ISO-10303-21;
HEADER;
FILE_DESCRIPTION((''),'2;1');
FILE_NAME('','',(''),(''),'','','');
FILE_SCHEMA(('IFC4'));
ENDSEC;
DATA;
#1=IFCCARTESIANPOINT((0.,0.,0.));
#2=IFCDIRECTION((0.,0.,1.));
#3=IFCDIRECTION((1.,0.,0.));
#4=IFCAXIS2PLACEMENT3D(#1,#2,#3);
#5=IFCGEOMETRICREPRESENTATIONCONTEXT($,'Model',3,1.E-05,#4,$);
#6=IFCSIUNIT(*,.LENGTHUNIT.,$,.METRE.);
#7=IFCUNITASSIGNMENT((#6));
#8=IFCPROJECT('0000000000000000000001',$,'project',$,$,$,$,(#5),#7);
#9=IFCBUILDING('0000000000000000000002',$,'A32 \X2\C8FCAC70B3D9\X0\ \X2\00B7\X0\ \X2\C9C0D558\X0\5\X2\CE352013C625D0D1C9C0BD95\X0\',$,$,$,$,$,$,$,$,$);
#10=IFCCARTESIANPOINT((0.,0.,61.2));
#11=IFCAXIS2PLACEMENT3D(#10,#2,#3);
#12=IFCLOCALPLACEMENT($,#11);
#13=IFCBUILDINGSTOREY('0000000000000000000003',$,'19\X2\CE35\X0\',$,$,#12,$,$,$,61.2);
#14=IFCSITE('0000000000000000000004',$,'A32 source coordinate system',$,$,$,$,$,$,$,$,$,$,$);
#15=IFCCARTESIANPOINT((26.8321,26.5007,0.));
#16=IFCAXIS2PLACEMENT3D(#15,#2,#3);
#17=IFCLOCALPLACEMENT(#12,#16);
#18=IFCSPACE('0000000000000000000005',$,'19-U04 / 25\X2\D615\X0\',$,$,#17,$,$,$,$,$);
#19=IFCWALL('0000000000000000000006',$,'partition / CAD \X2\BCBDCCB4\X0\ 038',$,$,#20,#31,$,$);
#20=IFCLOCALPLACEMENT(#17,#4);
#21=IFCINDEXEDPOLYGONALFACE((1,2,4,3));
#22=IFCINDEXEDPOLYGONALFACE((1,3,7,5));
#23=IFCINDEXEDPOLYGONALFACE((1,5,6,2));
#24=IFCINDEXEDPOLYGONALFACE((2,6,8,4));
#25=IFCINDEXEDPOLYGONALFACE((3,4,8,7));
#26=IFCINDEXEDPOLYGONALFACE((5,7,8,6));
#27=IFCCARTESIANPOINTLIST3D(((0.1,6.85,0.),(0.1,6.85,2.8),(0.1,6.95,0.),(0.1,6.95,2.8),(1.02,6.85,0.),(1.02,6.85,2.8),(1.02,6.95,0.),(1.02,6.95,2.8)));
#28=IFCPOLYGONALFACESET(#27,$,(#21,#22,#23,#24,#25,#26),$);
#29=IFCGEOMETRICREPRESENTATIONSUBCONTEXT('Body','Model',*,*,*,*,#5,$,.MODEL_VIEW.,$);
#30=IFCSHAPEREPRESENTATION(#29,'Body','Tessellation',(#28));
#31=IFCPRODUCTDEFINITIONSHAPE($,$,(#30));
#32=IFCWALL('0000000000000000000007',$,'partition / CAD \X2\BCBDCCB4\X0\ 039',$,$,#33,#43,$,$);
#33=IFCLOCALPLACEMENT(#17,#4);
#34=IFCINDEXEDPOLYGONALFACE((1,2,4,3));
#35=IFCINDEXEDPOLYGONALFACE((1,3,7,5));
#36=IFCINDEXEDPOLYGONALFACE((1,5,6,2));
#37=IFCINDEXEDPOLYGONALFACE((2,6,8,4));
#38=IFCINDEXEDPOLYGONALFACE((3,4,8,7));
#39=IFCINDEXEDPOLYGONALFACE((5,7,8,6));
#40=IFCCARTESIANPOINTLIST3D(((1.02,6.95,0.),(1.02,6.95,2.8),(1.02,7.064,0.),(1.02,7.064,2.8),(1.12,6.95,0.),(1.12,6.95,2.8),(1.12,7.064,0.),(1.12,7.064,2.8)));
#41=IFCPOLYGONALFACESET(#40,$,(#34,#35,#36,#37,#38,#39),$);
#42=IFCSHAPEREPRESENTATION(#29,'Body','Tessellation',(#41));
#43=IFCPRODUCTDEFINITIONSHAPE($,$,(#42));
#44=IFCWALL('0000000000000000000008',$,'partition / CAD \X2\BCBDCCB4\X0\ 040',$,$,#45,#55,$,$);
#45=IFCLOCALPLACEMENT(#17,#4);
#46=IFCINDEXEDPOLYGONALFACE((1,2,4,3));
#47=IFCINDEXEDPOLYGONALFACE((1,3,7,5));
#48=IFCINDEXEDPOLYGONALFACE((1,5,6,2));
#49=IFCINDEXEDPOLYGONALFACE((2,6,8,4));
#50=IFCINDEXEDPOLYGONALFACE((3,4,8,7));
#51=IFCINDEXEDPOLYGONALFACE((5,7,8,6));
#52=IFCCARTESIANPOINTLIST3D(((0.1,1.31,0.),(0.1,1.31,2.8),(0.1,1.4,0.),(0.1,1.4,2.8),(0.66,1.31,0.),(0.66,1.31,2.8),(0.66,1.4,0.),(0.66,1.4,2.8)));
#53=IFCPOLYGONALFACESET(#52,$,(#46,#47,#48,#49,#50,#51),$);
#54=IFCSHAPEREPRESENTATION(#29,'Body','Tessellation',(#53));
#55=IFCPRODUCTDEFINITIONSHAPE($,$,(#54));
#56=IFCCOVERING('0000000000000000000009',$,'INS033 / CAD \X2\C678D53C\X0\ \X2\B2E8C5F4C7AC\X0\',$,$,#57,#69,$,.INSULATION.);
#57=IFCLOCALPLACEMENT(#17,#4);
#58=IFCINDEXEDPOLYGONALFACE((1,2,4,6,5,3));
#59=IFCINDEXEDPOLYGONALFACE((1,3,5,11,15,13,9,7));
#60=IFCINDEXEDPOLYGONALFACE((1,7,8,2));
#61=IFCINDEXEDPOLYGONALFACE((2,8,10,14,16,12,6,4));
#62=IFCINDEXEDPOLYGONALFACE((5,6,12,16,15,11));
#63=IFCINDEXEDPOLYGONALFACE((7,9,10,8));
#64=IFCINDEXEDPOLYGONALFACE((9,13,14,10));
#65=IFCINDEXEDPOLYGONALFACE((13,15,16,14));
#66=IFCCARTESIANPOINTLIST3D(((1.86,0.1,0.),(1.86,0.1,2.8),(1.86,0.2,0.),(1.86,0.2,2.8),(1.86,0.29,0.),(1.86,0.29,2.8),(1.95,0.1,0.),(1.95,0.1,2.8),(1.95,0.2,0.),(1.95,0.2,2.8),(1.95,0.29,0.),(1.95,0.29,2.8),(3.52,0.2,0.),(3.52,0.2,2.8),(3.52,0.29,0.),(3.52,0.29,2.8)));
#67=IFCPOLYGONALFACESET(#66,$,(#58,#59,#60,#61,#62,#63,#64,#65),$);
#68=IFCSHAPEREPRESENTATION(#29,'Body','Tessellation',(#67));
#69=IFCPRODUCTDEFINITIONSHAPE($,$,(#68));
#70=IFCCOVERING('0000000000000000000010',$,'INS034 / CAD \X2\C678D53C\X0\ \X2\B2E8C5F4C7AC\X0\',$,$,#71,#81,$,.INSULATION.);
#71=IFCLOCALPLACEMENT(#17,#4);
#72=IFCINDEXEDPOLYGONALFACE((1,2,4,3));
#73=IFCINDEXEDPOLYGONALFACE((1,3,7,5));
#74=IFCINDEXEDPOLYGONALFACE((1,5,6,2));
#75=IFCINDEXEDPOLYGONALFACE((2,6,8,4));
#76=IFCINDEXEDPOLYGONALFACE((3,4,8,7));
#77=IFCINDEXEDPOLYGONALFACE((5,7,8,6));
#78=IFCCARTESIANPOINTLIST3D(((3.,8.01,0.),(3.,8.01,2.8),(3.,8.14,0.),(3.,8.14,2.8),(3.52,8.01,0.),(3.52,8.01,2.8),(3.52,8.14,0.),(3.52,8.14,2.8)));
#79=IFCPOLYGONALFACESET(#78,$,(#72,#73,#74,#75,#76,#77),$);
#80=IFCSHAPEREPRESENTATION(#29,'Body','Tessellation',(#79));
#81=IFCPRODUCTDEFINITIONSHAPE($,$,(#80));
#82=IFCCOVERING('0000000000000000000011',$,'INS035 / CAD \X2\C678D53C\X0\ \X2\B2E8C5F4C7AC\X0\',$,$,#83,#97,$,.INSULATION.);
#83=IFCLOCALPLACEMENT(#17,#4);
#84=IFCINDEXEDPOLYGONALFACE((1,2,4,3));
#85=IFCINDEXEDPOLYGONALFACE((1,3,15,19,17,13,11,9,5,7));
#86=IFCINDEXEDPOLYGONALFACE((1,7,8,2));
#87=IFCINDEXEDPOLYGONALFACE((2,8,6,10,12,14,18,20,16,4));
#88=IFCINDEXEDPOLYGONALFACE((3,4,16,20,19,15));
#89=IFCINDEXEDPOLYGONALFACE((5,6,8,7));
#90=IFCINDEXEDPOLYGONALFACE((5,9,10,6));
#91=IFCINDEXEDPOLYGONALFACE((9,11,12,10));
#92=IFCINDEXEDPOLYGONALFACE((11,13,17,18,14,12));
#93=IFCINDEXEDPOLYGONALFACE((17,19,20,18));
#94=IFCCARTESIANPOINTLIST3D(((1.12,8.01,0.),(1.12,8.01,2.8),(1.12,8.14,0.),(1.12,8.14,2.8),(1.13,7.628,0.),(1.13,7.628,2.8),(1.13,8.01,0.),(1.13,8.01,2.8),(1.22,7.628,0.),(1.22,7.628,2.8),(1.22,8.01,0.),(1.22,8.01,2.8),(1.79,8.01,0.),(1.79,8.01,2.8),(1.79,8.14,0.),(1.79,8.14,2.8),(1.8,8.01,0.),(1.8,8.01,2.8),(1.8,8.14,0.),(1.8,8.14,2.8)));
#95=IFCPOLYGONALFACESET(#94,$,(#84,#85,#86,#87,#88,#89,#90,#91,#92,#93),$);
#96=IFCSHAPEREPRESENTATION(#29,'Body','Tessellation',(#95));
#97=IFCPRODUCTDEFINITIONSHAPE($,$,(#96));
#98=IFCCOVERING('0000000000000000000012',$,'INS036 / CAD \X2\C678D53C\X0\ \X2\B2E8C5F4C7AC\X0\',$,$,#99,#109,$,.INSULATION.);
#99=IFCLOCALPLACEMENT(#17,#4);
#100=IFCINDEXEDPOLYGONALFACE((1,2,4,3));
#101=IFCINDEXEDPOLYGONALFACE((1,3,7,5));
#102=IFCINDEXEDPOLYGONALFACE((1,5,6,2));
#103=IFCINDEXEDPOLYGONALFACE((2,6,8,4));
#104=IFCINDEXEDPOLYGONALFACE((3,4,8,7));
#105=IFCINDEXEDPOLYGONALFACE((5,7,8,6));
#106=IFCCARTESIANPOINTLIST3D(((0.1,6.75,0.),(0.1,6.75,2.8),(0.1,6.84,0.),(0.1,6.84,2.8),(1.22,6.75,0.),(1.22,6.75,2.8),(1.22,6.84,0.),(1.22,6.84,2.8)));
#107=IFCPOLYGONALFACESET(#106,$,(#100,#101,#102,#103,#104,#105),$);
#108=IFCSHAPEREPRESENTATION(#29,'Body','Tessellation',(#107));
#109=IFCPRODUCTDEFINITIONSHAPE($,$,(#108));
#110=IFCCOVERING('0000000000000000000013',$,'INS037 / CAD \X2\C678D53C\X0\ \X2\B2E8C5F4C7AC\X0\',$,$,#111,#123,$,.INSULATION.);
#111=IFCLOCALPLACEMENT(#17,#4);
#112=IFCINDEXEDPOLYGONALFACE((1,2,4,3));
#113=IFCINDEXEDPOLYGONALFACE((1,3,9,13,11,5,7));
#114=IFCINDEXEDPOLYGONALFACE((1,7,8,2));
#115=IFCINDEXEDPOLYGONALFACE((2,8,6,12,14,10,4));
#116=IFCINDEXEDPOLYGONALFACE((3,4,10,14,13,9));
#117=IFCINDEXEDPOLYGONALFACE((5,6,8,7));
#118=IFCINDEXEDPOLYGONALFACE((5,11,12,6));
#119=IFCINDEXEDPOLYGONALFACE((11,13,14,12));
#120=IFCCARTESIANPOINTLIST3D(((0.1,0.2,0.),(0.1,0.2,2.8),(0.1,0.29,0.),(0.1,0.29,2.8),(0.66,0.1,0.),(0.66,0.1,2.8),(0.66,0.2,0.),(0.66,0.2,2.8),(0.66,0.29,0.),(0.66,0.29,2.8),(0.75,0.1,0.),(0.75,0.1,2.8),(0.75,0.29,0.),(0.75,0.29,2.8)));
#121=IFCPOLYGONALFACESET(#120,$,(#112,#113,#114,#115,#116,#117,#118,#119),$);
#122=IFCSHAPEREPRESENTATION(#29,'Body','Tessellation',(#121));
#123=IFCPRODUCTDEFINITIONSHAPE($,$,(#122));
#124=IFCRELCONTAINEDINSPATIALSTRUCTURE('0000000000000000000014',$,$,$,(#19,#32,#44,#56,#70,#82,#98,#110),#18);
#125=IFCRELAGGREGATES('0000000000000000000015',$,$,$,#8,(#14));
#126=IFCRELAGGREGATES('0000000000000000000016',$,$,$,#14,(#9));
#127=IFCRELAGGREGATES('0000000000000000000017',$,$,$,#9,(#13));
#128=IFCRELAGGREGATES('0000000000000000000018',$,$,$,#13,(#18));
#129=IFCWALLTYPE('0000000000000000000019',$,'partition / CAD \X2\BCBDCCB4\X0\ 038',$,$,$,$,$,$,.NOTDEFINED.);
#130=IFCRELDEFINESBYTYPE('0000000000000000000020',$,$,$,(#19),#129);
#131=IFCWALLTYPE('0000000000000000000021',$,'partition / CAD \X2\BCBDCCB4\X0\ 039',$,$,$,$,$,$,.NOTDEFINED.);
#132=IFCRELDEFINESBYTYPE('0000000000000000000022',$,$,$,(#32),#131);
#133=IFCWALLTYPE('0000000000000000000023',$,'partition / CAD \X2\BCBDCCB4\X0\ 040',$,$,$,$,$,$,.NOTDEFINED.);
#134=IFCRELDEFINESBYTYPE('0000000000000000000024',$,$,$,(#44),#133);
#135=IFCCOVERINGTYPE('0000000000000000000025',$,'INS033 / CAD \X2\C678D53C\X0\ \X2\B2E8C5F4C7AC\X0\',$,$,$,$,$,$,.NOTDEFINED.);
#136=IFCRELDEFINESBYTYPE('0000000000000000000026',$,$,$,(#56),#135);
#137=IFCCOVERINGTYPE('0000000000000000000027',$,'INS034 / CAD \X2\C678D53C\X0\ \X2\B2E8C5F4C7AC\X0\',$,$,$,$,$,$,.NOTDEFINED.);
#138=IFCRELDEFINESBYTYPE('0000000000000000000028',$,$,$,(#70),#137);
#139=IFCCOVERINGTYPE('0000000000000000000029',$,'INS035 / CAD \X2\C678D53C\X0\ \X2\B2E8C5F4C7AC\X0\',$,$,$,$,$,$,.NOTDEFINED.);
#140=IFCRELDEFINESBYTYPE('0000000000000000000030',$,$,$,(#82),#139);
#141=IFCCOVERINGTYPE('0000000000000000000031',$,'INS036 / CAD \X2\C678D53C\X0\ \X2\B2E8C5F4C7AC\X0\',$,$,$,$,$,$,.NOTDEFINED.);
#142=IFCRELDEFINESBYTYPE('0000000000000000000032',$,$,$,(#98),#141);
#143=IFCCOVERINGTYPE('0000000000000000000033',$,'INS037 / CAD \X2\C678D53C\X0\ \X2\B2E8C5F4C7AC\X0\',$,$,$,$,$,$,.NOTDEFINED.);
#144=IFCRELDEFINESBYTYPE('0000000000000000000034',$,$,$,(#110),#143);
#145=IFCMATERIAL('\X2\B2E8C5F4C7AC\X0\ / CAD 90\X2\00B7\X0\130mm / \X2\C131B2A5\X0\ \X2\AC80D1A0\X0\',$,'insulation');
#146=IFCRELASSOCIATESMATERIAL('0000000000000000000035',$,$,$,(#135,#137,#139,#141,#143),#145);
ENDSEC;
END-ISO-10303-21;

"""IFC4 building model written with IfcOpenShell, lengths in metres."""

from ifc_helpers import new_model, si_unit, frame, origin, origin_with_axes, place, context, subcontext, project, spatial, polyline, outline, extrude, source, transform, mapped, material, type_object, type_shapes, element, save


model = new_model("IFC4")

# Units and contexts
model_context = context("Model", 3, precision=1e-05, world=origin_with_axes())
body_context = subcontext(model_context, "Body", "Model", "MODEL_VIEW")
ifc_project = project(units=[si_unit("LENGTHUNIT", "METRE")], contexts=[model_context])

# Site, building, storey, space
storey_placement = place(None, frame((0.0, 0.0, 61.2), z_axis=(0.0, 0.0, 1.0), x_axis=(1.0, 0.0, 0.0)))
space_placement = place(storey_placement, frame((26.8321, 26.5007, 0.0), z_axis=(0.0, 0.0, 1.0), x_axis=(1.0, 0.0, 0.0)))
site = spatial("IfcSite", under=ifc_project, Name="A32 source coordinate system")
building = spatial("IfcBuilding", under=site, Name="A32 주거동 · 지하5층–옥탑지붕")
storey = spatial("IfcBuildingStorey", under=building, at=storey_placement, Name="19층", Elevation=61.2)
space = spatial("IfcSpace", under=storey, at=space_placement, Name="19-U04 / 25형")

# Walls
wall_type_1 = type_object("IfcWallType", Name="partition / CAD 벽체 038", PredefinedType="NOTDEFINED")
shared_shape_1 = source(origin(), body_context, "Body", "SweptSolid", [
    extrude(outline(polyline([(0.1, 6.95), (1.02, 6.95), (1.02, 6.85), (0.1, 6.85), (0.1, 6.95)])), origin(), (0.0, 0.0, 1.0), 2.8),
])
type_shapes(wall_type_1, [shared_shape_1])
wall_1_placement = place(space_placement, origin_with_axes())
element("IfcWall", 1, at=wall_1_placement, inside=space, type_object=wall_type_1, Name="partition / CAD 벽체 038", context=body_context, shape_type="MappedRepresentation", body=[
    mapped(shared_shape_1, transform((0.0, 0.0, 0.0), scale=1.0)),
])
wall_type_2 = type_object("IfcWallType", Name="partition / CAD 벽체 039", PredefinedType="NOTDEFINED")
shared_shape_2 = source(origin(), body_context, "Body", "SweptSolid", [
    extrude(outline(polyline([(1.02, 6.95), (1.02, 7.064), (1.12, 7.064), (1.12, 6.95), (1.02, 6.95)])), origin(), (0.0, 0.0, 1.0), 2.8),
])
type_shapes(wall_type_2, [shared_shape_2])
wall_2_placement = place(space_placement, origin_with_axes())
element("IfcWall", 2, at=wall_2_placement, inside=space, type_object=wall_type_2, Name="partition / CAD 벽체 039", context=body_context, shape_type="MappedRepresentation", body=[
    mapped(shared_shape_2, transform((0.0, 0.0, 0.0), scale=1.0)),
])
wall_type_3 = type_object("IfcWallType", Name="partition / CAD 벽체 040", PredefinedType="NOTDEFINED")
shared_shape_3 = source(origin(), body_context, "Body", "SweptSolid", [
    extrude(outline(polyline([(0.1, 1.4), (0.66, 1.4), (0.66, 1.31), (0.1, 1.31), (0.1, 1.4)])), origin(), (0.0, 0.0, 1.0), 2.8),
])
type_shapes(wall_type_3, [shared_shape_3])
wall_3_placement = place(space_placement, origin_with_axes())
element("IfcWall", 3, at=wall_3_placement, inside=space, type_object=wall_type_3, Name="partition / CAD 벽체 040", context=body_context, shape_type="MappedRepresentation", body=[
    mapped(shared_shape_3, transform((0.0, 0.0, 0.0), scale=1.0)),
])

# Coverings
ifc_material = material(Name="단열재 / CAD 90·130mm / 성능 검토", Category="insulation")
covering_type_1 = type_object("IfcCoveringType", Name="INS033 / CAD 외피 단열재", PredefinedType="NOTDEFINED", material=ifc_material)
shared_shape_4 = source(origin(), body_context, "Body", "SweptSolid", [
    extrude(outline(polyline([(1.95, 0.29), (3.52, 0.29), (3.52, 0.2), (1.95, 0.2), (1.95, 0.1), (1.86, 0.1), (1.86, 0.2), (1.86, 0.29), (1.95, 0.29)])), origin(), (0.0, 0.0, 1.0), 2.8),
])
type_shapes(covering_type_1, [shared_shape_4])
covering_1_placement = place(space_placement, origin_with_axes())
element("IfcCovering", 4, at=covering_1_placement, inside=space, type_object=covering_type_1, Name="INS033 / CAD 외피 단열재", PredefinedType="INSULATION", context=body_context, shape_type="MappedRepresentation", body=[
    mapped(shared_shape_4, transform((0.0, 0.0, 0.0), scale=1.0)),
])
covering_type_2 = type_object("IfcCoveringType", Name="INS034 / CAD 외피 단열재", PredefinedType="NOTDEFINED", material=ifc_material)
shared_shape_5 = source(origin(), body_context, "Body", "SweptSolid", [
    extrude(outline(polyline([(3.52, 8.01), (3.0, 8.01), (3.0, 8.14), (3.52, 8.14), (3.52, 8.01)])), origin(), (0.0, 0.0, 1.0), 2.8),
])
type_shapes(covering_type_2, [shared_shape_5])
covering_2_placement = place(space_placement, origin_with_axes())
element("IfcCovering", 5, at=covering_2_placement, inside=space, type_object=covering_type_2, Name="INS034 / CAD 외피 단열재", PredefinedType="INSULATION", context=body_context, shape_type="MappedRepresentation", body=[
    mapped(shared_shape_5, transform((0.0, 0.0, 0.0), scale=1.0)),
])
covering_type_3 = type_object("IfcCoveringType", Name="INS035 / CAD 외피 단열재", PredefinedType="NOTDEFINED", material=ifc_material)
shared_shape_6 = source(origin(), body_context, "Body", "SweptSolid", [
    extrude(outline(polyline([(1.8, 8.01), (1.79, 8.01), (1.22, 8.01), (1.22, 7.628), (1.13, 7.628), (1.13, 8.01), (1.12, 8.01), (1.12, 8.14), (1.79, 8.14), (1.8, 8.14), (1.8, 8.01)])), origin(), (0.0, 0.0, 1.0), 2.8),
])
type_shapes(covering_type_3, [shared_shape_6])
covering_3_placement = place(space_placement, origin_with_axes())
element("IfcCovering", 6, at=covering_3_placement, inside=space, type_object=covering_type_3, Name="INS035 / CAD 외피 단열재", PredefinedType="INSULATION", context=body_context, shape_type="MappedRepresentation", body=[
    mapped(shared_shape_6, transform((0.0, 0.0, 0.0), scale=1.0)),
])
covering_type_4 = type_object("IfcCoveringType", Name="INS036 / CAD 외피 단열재", PredefinedType="NOTDEFINED", material=ifc_material)
shared_shape_7 = source(origin(), body_context, "Body", "SweptSolid", [
    extrude(outline(polyline([(1.22, 6.84), (1.22, 6.75), (0.1, 6.75), (0.1, 6.84), (1.22, 6.84)])), origin(), (0.0, 0.0, 1.0), 2.8),
])
type_shapes(covering_type_4, [shared_shape_7])
covering_4_placement = place(space_placement, origin_with_axes())
element("IfcCovering", 7, at=covering_4_placement, inside=space, type_object=covering_type_4, Name="INS036 / CAD 외피 단열재", PredefinedType="INSULATION", context=body_context, shape_type="MappedRepresentation", body=[
    mapped(shared_shape_7, transform((0.0, 0.0, 0.0), scale=1.0)),
])
covering_type_5 = type_object("IfcCoveringType", Name="INS037 / CAD 외피 단열재", PredefinedType="NOTDEFINED", material=ifc_material)
shared_shape_8 = source(origin(), body_context, "Body", "SweptSolid", [
    extrude(outline(polyline([(0.1, 0.2), (0.1, 0.29), (0.66, 0.29), (0.75, 0.29), (0.75, 0.1), (0.66, 0.1), (0.66, 0.2), (0.1, 0.2)])), origin(), (0.0, 0.0, 1.0), 2.8),
])
type_shapes(covering_type_5, [shared_shape_8])
covering_5_placement = place(space_placement, origin_with_axes())
element("IfcCovering", 8, at=covering_5_placement, inside=space, type_object=covering_type_5, Name="INS037 / CAD 외피 단열재", PredefinedType="INSULATION", context=body_context, shape_type="MappedRepresentation", body=[
    mapped(shared_shape_8, transform((0.0, 0.0, 0.0), scale=1.0)),
])

save(model, "model.ifc")
